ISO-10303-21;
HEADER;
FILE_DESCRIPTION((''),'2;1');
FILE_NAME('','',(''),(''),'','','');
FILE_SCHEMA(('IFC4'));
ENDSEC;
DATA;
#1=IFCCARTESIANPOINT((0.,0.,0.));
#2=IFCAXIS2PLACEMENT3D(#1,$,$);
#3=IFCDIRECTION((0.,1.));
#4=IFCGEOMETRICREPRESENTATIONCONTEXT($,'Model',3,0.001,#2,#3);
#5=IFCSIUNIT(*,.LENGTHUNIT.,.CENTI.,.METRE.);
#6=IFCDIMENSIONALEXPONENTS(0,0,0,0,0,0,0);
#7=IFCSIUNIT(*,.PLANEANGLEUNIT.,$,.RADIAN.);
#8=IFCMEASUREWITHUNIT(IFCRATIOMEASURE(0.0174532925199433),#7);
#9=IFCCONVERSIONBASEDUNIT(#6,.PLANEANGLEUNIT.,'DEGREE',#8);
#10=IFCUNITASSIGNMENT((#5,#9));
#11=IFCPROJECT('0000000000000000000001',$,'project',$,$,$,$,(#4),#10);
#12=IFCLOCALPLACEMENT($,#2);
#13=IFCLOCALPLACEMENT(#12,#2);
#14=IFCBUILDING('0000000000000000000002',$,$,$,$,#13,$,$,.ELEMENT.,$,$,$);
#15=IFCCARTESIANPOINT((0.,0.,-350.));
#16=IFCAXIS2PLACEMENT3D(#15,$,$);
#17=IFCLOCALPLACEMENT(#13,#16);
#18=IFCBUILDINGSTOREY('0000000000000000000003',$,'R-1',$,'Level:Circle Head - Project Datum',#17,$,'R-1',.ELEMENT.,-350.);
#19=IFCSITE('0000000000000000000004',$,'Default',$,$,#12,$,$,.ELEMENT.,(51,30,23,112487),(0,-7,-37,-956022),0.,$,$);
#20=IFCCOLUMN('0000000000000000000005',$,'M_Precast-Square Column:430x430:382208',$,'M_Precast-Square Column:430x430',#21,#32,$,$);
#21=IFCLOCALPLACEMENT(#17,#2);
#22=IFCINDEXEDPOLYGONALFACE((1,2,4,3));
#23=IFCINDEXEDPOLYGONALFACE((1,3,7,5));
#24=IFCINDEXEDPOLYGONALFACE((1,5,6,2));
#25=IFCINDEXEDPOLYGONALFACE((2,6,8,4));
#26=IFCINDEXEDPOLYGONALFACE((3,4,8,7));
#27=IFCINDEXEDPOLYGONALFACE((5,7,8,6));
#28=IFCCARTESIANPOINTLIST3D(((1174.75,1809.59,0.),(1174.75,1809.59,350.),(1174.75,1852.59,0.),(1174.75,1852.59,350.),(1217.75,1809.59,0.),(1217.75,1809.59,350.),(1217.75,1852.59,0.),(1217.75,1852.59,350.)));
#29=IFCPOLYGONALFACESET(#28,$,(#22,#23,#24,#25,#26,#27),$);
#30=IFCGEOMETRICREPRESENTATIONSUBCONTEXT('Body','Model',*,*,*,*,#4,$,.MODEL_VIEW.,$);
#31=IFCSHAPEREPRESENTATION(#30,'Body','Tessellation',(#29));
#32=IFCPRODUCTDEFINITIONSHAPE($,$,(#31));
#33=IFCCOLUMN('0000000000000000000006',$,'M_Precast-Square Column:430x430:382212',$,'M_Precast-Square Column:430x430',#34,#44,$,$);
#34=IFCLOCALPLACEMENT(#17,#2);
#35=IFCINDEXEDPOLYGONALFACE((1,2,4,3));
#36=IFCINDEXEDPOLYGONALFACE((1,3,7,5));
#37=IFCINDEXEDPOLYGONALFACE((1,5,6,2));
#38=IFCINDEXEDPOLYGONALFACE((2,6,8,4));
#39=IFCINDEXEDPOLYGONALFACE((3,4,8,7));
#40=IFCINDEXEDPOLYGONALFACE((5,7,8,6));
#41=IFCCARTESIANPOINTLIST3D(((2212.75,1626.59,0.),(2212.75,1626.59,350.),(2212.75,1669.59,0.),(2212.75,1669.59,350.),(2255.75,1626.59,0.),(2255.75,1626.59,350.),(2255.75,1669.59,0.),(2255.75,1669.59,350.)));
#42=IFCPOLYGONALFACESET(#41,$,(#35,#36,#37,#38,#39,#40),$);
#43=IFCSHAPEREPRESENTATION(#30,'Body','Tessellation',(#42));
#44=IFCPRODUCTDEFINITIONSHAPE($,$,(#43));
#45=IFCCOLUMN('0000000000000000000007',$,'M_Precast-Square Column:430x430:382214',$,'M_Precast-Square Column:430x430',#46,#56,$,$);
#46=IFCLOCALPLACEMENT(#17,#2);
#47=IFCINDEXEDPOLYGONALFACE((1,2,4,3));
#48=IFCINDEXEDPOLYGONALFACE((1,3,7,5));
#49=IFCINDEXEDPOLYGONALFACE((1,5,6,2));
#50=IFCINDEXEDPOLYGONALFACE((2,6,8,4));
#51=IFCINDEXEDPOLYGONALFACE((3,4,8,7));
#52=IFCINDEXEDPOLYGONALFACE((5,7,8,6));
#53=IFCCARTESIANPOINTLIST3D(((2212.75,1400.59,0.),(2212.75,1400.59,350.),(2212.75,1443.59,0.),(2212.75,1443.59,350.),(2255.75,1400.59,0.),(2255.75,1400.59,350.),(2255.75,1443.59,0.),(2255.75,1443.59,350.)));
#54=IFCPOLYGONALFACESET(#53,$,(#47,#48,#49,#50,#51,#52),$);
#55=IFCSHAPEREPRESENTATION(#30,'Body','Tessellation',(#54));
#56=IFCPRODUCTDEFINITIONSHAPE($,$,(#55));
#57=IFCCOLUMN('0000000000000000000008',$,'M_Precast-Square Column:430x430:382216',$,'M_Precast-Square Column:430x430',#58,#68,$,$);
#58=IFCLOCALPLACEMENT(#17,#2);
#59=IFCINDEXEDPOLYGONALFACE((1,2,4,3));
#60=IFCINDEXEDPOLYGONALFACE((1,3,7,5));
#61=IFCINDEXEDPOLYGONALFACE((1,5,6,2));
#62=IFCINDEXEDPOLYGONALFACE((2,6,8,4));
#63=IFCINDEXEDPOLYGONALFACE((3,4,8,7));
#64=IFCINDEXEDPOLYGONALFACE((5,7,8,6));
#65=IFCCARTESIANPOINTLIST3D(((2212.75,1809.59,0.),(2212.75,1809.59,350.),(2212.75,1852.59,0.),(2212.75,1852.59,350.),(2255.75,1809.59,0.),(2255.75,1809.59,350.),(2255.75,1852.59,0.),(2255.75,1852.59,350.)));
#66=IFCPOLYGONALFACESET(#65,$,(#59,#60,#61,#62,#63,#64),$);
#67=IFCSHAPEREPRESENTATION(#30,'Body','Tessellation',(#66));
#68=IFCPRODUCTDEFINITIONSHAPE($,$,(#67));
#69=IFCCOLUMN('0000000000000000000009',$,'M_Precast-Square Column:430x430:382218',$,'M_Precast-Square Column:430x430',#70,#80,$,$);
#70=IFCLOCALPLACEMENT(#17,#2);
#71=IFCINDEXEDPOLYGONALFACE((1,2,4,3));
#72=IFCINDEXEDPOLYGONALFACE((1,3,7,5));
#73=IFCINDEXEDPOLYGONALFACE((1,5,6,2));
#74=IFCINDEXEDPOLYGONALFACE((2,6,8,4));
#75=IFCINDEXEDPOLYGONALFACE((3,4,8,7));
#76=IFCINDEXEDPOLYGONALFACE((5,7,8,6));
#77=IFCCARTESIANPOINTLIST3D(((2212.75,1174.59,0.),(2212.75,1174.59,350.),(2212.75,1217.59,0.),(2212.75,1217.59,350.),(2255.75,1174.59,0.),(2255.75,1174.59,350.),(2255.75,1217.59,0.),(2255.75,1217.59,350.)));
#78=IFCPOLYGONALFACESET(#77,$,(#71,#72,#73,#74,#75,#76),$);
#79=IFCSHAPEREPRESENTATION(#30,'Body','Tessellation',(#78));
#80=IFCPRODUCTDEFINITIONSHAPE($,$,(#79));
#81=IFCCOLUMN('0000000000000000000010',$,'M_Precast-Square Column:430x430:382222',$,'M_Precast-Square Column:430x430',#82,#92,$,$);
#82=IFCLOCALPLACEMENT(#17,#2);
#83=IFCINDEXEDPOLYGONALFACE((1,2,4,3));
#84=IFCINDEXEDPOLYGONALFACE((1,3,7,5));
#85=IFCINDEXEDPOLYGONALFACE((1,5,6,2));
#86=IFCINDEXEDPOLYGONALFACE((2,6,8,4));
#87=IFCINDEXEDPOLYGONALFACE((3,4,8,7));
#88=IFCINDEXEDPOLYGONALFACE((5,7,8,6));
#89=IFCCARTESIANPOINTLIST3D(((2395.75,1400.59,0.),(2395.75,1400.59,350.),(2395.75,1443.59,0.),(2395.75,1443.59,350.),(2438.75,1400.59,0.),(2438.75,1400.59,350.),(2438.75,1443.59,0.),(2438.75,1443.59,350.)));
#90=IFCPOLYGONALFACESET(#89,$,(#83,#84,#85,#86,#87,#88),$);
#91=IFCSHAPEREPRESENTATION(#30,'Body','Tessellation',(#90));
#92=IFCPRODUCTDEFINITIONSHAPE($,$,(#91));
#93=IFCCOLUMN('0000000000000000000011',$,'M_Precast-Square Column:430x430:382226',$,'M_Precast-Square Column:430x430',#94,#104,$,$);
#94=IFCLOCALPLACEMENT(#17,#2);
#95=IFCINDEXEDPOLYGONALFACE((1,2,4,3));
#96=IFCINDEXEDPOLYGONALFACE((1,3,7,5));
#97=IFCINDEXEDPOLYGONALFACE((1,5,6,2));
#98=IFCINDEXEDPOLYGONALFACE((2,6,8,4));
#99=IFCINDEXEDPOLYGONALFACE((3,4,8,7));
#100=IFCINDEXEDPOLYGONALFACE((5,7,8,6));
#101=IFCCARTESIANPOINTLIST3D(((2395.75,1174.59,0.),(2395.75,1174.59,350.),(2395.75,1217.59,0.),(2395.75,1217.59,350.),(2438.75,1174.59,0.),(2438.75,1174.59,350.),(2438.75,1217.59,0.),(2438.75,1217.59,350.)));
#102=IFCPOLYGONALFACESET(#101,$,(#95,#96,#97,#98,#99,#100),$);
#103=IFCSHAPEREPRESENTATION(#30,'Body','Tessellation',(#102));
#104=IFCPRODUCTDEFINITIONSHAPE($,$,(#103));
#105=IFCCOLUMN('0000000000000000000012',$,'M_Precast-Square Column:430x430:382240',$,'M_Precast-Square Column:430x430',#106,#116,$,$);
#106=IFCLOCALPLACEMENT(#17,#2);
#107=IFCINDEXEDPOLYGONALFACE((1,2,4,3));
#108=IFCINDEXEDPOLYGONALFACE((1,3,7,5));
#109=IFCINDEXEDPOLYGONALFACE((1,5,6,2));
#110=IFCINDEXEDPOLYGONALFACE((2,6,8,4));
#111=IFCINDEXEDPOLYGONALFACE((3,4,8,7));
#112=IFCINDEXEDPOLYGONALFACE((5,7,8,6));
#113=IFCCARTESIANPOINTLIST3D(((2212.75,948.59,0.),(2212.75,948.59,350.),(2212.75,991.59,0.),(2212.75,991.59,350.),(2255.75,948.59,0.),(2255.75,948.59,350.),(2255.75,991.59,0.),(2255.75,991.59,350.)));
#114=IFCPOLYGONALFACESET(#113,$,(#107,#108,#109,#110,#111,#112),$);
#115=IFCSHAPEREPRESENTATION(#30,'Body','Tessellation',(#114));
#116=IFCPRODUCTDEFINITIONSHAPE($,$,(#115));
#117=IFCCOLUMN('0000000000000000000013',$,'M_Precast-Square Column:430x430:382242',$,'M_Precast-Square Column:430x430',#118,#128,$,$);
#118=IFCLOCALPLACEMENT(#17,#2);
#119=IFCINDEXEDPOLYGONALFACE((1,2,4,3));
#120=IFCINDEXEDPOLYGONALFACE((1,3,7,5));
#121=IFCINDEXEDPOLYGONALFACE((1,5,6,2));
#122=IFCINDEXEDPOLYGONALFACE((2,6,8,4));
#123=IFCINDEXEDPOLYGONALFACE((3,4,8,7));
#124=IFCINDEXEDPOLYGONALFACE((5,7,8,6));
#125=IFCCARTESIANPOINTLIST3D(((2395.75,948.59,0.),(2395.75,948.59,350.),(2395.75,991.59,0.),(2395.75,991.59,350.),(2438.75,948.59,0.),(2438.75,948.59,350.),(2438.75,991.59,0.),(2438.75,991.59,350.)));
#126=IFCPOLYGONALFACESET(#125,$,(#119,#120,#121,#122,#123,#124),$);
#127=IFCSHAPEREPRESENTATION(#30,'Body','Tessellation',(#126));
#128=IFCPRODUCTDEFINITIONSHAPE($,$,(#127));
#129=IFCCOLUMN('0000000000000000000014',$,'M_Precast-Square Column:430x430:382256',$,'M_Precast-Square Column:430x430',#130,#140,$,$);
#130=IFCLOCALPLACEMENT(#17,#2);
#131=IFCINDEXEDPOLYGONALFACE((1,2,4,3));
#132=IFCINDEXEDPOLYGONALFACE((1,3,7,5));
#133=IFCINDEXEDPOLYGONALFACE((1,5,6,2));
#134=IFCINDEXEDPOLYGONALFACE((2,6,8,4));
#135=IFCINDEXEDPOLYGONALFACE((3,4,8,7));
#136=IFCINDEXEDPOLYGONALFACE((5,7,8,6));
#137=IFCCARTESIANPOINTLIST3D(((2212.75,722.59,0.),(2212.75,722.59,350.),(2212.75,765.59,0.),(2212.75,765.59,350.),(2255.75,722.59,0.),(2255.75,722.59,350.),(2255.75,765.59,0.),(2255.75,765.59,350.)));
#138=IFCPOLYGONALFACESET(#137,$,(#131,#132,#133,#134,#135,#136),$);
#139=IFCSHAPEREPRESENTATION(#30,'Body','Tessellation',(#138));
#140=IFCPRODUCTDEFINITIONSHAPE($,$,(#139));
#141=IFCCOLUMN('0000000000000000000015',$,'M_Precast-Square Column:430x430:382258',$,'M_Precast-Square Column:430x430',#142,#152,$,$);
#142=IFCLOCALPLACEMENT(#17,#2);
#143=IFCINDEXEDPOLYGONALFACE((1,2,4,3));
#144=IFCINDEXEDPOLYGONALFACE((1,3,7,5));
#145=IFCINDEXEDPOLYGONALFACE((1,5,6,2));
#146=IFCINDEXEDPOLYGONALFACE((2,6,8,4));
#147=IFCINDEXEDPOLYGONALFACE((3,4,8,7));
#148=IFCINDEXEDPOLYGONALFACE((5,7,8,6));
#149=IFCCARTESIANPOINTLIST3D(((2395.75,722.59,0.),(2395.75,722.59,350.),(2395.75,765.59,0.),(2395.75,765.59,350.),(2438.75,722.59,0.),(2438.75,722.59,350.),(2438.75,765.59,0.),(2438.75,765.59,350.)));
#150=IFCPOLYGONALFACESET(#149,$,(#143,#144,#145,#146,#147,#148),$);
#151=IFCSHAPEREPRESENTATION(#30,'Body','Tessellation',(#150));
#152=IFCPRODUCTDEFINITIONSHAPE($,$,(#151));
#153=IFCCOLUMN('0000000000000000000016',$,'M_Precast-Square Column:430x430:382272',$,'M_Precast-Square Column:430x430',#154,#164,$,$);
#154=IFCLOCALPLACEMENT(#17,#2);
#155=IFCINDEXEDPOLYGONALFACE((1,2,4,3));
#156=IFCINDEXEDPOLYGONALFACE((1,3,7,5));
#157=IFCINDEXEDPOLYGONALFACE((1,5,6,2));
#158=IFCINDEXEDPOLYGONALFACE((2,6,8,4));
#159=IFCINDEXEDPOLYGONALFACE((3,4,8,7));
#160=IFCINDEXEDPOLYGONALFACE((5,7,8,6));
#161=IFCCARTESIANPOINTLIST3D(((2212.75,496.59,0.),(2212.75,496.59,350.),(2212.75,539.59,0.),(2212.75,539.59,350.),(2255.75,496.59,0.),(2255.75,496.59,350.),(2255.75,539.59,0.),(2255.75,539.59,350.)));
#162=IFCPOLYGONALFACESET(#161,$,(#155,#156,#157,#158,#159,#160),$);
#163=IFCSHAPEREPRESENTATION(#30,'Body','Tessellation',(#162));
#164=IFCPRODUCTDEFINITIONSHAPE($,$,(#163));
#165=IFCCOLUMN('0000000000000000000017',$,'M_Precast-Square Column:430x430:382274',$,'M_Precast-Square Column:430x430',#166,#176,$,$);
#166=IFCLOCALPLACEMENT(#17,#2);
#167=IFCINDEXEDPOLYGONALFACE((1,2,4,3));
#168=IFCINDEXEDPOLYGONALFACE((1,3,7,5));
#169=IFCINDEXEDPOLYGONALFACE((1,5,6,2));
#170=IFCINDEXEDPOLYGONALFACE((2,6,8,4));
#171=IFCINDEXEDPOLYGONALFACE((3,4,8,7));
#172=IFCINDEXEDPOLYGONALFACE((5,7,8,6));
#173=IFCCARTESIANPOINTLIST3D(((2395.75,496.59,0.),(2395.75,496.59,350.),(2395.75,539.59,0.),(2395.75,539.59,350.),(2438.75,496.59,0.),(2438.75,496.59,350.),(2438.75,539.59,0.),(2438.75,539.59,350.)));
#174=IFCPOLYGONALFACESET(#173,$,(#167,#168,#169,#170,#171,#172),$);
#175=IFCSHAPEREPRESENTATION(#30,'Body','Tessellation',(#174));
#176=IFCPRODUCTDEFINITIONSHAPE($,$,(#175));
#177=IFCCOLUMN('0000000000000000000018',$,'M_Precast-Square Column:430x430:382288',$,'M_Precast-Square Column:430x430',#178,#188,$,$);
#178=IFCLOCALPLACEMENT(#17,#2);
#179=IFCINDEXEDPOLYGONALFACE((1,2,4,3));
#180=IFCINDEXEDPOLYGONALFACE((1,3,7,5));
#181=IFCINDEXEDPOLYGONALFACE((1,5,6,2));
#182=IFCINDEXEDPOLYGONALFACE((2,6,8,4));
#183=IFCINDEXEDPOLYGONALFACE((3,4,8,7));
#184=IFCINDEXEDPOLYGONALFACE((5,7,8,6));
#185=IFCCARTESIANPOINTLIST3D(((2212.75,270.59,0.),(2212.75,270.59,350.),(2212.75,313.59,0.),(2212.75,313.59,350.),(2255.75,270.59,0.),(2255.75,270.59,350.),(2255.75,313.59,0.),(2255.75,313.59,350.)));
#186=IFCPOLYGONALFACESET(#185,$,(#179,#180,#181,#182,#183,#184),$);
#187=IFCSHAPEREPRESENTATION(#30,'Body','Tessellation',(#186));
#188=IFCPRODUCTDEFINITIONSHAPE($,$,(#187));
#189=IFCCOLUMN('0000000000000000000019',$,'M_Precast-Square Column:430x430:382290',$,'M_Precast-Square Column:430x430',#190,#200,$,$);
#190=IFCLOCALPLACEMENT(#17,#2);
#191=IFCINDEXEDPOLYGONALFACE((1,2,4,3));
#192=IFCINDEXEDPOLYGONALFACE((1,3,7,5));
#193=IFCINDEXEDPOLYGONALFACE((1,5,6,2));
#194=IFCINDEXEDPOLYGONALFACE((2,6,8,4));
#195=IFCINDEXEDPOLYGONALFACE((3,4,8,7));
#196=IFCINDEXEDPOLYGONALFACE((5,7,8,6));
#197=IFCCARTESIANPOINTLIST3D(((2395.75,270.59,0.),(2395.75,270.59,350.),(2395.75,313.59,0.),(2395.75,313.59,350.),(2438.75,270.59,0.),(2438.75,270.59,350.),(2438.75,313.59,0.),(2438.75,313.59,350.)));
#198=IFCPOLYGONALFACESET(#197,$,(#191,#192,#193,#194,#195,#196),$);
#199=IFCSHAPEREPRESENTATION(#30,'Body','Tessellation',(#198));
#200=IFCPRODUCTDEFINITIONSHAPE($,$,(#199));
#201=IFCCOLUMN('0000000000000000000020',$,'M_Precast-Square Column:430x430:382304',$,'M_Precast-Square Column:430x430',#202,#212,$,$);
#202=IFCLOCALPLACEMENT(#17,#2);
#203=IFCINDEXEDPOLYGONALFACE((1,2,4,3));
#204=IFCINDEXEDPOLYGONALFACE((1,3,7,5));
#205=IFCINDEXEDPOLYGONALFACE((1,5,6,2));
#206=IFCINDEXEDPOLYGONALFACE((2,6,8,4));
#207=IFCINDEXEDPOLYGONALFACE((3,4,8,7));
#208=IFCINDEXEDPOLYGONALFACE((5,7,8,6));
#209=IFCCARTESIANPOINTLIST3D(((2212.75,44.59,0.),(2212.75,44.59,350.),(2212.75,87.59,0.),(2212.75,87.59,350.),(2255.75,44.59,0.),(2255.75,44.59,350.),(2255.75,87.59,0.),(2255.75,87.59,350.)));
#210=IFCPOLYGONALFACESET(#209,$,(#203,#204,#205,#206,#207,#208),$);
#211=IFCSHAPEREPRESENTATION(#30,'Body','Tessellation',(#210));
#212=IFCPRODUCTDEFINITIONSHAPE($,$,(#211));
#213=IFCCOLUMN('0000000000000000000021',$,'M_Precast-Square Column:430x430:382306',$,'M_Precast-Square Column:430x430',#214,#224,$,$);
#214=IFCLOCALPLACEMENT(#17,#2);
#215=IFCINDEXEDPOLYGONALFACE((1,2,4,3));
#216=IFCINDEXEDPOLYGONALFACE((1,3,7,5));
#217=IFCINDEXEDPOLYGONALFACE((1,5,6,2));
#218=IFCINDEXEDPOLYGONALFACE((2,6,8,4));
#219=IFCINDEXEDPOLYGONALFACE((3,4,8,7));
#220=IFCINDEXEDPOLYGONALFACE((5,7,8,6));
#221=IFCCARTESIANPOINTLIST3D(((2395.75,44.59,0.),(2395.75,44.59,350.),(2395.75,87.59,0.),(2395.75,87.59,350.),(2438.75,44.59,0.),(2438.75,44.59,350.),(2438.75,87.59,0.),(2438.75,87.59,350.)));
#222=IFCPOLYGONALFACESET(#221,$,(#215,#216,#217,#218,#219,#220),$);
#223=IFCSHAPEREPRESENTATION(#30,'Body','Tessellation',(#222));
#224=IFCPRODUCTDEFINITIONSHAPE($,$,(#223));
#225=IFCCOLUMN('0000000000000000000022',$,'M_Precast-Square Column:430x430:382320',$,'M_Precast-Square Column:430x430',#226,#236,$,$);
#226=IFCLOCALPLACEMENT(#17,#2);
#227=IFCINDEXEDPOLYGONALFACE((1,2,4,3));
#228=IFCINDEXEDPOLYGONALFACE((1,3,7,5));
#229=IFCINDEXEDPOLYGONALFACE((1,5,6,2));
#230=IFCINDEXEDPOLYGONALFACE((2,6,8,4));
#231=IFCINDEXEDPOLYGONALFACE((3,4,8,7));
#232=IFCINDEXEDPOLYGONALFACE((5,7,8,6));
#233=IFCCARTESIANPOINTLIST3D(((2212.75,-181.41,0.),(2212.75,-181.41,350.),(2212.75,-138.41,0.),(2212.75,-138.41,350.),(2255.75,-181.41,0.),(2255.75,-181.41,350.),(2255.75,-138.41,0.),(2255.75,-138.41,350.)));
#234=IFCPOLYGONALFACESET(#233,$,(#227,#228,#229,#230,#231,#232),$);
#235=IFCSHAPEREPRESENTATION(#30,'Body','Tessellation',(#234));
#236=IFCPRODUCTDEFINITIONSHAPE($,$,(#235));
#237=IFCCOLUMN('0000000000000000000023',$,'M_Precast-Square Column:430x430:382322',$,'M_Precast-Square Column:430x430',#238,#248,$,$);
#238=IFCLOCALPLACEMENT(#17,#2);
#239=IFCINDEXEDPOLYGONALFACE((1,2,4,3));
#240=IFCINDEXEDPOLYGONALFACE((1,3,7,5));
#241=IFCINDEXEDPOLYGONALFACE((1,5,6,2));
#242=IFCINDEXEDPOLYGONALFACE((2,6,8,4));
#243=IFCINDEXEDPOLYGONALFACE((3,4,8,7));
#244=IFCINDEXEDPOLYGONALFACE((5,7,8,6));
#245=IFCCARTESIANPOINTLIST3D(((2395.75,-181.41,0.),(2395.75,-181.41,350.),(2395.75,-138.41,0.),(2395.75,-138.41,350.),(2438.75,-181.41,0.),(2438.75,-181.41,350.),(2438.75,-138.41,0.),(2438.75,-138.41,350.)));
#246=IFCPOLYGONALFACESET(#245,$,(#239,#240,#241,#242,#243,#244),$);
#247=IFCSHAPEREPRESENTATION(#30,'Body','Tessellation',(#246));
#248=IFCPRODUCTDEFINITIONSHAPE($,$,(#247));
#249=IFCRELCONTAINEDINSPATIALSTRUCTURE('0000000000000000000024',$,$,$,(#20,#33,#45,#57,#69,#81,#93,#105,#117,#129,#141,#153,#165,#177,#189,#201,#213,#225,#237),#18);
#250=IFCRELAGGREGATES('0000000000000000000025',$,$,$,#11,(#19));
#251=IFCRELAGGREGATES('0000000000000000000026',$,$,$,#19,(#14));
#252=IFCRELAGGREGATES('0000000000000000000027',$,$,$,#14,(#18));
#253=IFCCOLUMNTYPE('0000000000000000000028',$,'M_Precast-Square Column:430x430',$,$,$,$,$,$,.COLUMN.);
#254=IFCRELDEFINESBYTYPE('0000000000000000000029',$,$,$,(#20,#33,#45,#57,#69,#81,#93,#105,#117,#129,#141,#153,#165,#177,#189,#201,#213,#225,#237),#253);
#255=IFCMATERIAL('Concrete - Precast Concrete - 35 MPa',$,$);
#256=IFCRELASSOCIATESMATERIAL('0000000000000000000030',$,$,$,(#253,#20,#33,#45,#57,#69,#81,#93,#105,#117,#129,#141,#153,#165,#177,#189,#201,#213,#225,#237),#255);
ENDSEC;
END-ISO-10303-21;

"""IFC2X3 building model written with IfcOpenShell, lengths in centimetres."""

from ifc_helpers import new_model, entity, si_unit, converted_unit, direction, frame, origin, origin_2d_with_axis, place, context, subcontext, project, spatial, rectangle, extrude, source, transform, mapped, material, type_object, type_shapes, element, save


model = new_model("IFC2X3")

# Units and contexts
model_context = context("Model", 3, precision=0.001, world=origin(), true_north=direction((0.0, 1.0)))
body_context = subcontext(model_context, "Body", "Model", "MODEL_VIEW")
ifc_project = project(units=[si_unit("LENGTHUNIT", "METRE", prefix="CENTI"), converted_unit("PLANEANGLEUNIT", "DEGREE", entity("IfcRatioMeasure", 0.0174532925199433), si_unit("PLANEANGLEUNIT", "RADIAN"), dimensions=[0, 0, 0, 0, 0, 0, 0])], contexts=[model_context])

# Site, building, storey
site_placement = place(None, origin())
site = spatial("IfcSite", under=ifc_project, at=site_placement, Name="Default", CompositionType="ELEMENT", RefLatitude=(51, 30, 23, 112487), RefLongitude=(0, -7, -37, -956022), RefElevation=0.0)
building_placement = place(site_placement, origin())
building = spatial("IfcBuilding", under=site, at=building_placement, CompositionType="ELEMENT")
storey_placement = place(building_placement, frame((0.0, 0.0, -350.0)))
storey = spatial("IfcBuildingStorey", under=building, at=storey_placement, Name="R-1", ObjectType="Level:Circle Head - Project Datum", LongName="R-1", CompositionType="ELEMENT", Elevation=-350.0)

# Columns
ifc_material_1 = material(Name="Concrete - Precast Concrete - 35 MPa")
column_type = type_object("IfcColumnType", Name="M_Precast-Square Column:430x430", PredefinedType="COLUMN", material=ifc_material_1)
shared_shape = source(origin(), body_context, "Body", "SweptSolid", [
    extrude(rectangle(XDim=43.0, YDim=43.0, at=origin_2d_with_axis()), frame((0.0, 0.0, -350.0), z_axis=(0.0, 0.0, 1.0), x_axis=(0.0, -1.0, 0.0)), (0.0, 0.0, 1.0), 350.0),
])
type_shapes(column_type, [shared_shape])
for number, where, z_axis, x_axis, name in (
    (1, (1196.25, 1831.09, 350.0), (0.0, 0.0, 1.0), (-1.0, 0.0, 0.0), "M_Precast-Square Column:430x430:382208"),
    (2, (2234.25, 1648.09, 350.0), (0.0, 0.0, 1.0), (-1.0, 0.0, 0.0), "M_Precast-Square Column:430x430:382212"),
    (3, (2234.25, 1422.09, 350.0), (0.0, 0.0, 1.0), (-1.0, 0.0, 0.0), "M_Precast-Square Column:430x430:382214"),
    (4, (2234.25, 1831.09, 350.0), (0.0, 0.0, 1.0), (-1.0, 0.0, 0.0), "M_Precast-Square Column:430x430:382216"),
    (5, (2234.25, 1196.09, 350.0), (0.0, 0.0, 1.0), (-1.0, 0.0, 0.0), "M_Precast-Square Column:430x430:382218"),
    (6, (2417.25, 1422.09, 350.0), (0.0, 0.0, 1.0), (-1.0, 0.0, 0.0), "M_Precast-Square Column:430x430:382222"),
    (7, (2417.25, 1196.09, 350.0), (0.0, 0.0, 1.0), (-1.0, 0.0, 0.0), "M_Precast-Square Column:430x430:382226"),
    (8, (2234.25, 970.09, 350.0), (0.0, 0.0, 1.0), (-1.0, 0.0, 0.0), "M_Precast-Square Column:430x430:382240"),
    (9, (2417.25, 970.09, 350.0), (0.0, 0.0, 1.0), (-1.0, 0.0, 0.0), "M_Precast-Square Column:430x430:382242"),
    (10, (2234.25, 744.09, 350.0), (0.0, 0.0, 1.0), (-1.0, 0.0, 0.0), "M_Precast-Square Column:430x430:382256"),
    (11, (2417.25, 744.09, 350.0), (0.0, 0.0, 1.0), (-1.0, 0.0, 0.0), "M_Precast-Square Column:430x430:382258"),
    (12, (2234.25, 518.09, 350.0), (0.0, 0.0, 1.0), (-1.0, 0.0, 0.0), "M_Precast-Square Column:430x430:382272"),
    (13, (2417.25, 518.09, 350.0), (0.0, 0.0, 1.0), (-1.0, 0.0, 0.0), "M_Precast-Square Column:430x430:382274"),
    (14, (2234.25, 292.09, 350.0), (0.0, 0.0, 1.0), (-1.0, 0.0, 0.0), "M_Precast-Square Column:430x430:382288"),
    (15, (2417.25, 292.09, 350.0), (0.0, 0.0, 1.0), (-1.0, 0.0, 0.0), "M_Precast-Square Column:430x430:382290"),
    (16, (2234.25, 66.09, 350.0), (0.0, 0.0, 1.0), (-1.0, 0.0, 0.0), "M_Precast-Square Column:430x430:382304"),
    (17, (2417.25, 66.09, 350.0), (0.0, 0.0, 1.0), (-1.0, 0.0, 0.0), "M_Precast-Square Column:430x430:382306"),
    (18, (2234.25, -159.91, 350.0), (0.0, 0.0, 1.0), (-1.0, 0.0, 0.0), "M_Precast-Square Column:430x430:382320"),
    (19, (2417.25, -159.91, 350.0), (0.0, 0.0, 1.0), (-1.0, 0.0, 0.0), "M_Precast-Square Column:430x430:382322"),
):
    element("IfcColumn", number, at=place(storey_placement, frame(where, z_axis=z_axis, x_axis=x_axis)), inside=storey, type_object=column_type, material=ifc_material_1, Name=name, ObjectType="M_Precast-Square Column:430x430", context=body_context, shape_type="MappedRepresentation", body=[
        mapped(shared_shape, transform((0.0, 0.0, 0.0), scale=1.0)),
    ])

save(model, "model.ifc")
